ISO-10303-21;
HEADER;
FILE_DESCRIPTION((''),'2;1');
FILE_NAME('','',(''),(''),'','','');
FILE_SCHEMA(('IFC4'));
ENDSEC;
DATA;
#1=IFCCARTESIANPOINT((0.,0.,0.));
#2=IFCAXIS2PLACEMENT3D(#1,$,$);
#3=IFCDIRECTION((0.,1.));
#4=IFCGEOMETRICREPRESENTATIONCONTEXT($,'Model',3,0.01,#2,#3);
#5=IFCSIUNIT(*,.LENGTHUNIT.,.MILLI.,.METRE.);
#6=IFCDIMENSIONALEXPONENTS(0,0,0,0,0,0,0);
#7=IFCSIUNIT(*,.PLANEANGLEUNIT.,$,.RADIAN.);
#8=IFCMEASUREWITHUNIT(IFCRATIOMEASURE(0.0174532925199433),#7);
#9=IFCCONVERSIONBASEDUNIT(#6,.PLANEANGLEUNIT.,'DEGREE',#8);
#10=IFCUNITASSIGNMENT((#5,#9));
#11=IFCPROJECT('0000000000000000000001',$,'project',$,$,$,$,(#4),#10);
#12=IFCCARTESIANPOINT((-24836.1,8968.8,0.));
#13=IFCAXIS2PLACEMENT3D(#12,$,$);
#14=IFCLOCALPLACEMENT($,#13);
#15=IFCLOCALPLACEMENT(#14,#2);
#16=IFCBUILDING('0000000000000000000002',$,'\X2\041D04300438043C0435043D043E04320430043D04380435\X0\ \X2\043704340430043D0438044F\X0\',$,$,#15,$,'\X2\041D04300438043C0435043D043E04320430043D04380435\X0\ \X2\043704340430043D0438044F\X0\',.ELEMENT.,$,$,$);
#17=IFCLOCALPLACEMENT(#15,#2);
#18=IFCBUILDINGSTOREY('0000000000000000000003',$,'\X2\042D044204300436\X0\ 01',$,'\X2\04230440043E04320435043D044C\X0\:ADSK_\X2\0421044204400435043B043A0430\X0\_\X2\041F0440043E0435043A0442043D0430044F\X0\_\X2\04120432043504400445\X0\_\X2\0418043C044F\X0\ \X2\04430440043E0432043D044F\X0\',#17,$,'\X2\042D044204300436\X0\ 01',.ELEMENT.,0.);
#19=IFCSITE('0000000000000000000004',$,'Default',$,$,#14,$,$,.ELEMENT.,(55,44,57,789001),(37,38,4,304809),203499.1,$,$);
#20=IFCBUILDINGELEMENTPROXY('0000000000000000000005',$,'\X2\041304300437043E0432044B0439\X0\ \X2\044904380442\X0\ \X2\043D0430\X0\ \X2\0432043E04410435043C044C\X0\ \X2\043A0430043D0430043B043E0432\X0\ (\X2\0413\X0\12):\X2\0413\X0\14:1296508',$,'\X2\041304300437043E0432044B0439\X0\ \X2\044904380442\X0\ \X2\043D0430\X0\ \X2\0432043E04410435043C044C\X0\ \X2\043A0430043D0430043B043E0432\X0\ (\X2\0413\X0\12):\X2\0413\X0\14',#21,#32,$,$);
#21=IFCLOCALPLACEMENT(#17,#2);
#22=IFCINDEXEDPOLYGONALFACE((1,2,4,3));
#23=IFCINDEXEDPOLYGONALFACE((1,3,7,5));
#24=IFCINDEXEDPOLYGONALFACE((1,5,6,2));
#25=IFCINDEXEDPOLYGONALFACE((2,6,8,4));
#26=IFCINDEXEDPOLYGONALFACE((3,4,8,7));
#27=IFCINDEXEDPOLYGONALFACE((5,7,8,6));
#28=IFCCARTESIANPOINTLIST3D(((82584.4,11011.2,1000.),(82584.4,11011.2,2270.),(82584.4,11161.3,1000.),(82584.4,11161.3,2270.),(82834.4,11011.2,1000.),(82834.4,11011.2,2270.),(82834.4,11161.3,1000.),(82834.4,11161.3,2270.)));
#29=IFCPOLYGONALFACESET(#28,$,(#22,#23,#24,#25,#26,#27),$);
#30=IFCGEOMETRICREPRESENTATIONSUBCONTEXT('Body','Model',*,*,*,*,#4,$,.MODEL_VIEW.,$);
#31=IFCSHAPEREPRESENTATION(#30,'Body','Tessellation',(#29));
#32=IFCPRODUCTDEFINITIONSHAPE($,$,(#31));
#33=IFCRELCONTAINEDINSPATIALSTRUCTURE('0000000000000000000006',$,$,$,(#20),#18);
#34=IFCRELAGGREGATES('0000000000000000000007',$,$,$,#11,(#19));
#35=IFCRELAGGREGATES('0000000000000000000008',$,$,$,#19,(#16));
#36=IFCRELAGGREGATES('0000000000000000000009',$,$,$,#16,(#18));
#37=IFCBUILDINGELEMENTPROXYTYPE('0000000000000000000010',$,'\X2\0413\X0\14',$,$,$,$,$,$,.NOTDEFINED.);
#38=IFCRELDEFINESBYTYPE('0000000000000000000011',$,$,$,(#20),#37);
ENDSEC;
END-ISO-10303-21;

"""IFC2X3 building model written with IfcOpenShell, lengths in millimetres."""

from ifc_helpers import new_model, entity, si_unit, converted_unit, direction, frame, origin, origin_2d_with_axis, place, context, subcontext, project, spatial, rectangle, extrude, type_object, element, save


model = new_model("IFC2X3")

# Units and contexts
model_context = context("Model", 3, precision=0.01, world=origin(), true_north=direction((0.0, 1.0)))
body_context = subcontext(model_context, "Body", "Model", "MODEL_VIEW")
ifc_project = project(units=[si_unit("LENGTHUNIT", "METRE", prefix="MILLI"), converted_unit("PLANEANGLEUNIT", "DEGREE", entity("IfcRatioMeasure", 0.0174532925199433), si_unit("PLANEANGLEUNIT", "RADIAN"), dimensions=[0, 0, 0, 0, 0, 0, 0])], contexts=[model_context])

# Site, building, storey
site_placement = place(None, frame((-24836.1, 8968.8, 0.0)))
site = spatial("IfcSite", under=ifc_project, at=site_placement, Name="Default", CompositionType="ELEMENT", RefLatitude=(55, 44, 57, 789001), RefLongitude=(37, 38, 4, 304809), RefElevation=203499.1)
building_placement = place(site_placement, origin())
building = spatial("IfcBuilding", under=site, at=building_placement, Name="Наименование здания", LongName="Наименование здания", CompositionType="ELEMENT")
storey_placement = place(building_placement, origin())
storey = spatial("IfcBuildingStorey", under=building, at=storey_placement, Name="Этаж 01", ObjectType="Уровень:ADSK_Стрелка_Проектная_Вверх_Имя уровня", LongName="Этаж 01", CompositionType="ELEMENT", Elevation=0.0)

# Building element proxy
building_element_proxy_type = type_object("IfcBuildingElementProxyType", Name="Г14", PredefinedType="NOTDEFINED")
proxy_placement = place(storey_placement, frame((82584.4, 11011.2, 1000.0)))
element("IfcBuildingElementProxy", 1, at=proxy_placement, inside=storey, type_object=building_element_proxy_type, Name="Газовый щит на восемь каналов (Г12):Г14:1296508", ObjectType="Газовый щит на восемь каналов (Г12):Г14", context=body_context, shape_type="SweptSolid", body=[
    extrude(rectangle(XDim=150.0, YDim=250.0, at=origin_2d_with_axis()), frame((125.0, 75.0, 0.0), z_axis=(0.0, 0.0, 1.0), x_axis=(0.0, 1.0, 0.0)), (0.0, 0.0, 1.0), 1270.0),
])

save(model, "model.ifc")
